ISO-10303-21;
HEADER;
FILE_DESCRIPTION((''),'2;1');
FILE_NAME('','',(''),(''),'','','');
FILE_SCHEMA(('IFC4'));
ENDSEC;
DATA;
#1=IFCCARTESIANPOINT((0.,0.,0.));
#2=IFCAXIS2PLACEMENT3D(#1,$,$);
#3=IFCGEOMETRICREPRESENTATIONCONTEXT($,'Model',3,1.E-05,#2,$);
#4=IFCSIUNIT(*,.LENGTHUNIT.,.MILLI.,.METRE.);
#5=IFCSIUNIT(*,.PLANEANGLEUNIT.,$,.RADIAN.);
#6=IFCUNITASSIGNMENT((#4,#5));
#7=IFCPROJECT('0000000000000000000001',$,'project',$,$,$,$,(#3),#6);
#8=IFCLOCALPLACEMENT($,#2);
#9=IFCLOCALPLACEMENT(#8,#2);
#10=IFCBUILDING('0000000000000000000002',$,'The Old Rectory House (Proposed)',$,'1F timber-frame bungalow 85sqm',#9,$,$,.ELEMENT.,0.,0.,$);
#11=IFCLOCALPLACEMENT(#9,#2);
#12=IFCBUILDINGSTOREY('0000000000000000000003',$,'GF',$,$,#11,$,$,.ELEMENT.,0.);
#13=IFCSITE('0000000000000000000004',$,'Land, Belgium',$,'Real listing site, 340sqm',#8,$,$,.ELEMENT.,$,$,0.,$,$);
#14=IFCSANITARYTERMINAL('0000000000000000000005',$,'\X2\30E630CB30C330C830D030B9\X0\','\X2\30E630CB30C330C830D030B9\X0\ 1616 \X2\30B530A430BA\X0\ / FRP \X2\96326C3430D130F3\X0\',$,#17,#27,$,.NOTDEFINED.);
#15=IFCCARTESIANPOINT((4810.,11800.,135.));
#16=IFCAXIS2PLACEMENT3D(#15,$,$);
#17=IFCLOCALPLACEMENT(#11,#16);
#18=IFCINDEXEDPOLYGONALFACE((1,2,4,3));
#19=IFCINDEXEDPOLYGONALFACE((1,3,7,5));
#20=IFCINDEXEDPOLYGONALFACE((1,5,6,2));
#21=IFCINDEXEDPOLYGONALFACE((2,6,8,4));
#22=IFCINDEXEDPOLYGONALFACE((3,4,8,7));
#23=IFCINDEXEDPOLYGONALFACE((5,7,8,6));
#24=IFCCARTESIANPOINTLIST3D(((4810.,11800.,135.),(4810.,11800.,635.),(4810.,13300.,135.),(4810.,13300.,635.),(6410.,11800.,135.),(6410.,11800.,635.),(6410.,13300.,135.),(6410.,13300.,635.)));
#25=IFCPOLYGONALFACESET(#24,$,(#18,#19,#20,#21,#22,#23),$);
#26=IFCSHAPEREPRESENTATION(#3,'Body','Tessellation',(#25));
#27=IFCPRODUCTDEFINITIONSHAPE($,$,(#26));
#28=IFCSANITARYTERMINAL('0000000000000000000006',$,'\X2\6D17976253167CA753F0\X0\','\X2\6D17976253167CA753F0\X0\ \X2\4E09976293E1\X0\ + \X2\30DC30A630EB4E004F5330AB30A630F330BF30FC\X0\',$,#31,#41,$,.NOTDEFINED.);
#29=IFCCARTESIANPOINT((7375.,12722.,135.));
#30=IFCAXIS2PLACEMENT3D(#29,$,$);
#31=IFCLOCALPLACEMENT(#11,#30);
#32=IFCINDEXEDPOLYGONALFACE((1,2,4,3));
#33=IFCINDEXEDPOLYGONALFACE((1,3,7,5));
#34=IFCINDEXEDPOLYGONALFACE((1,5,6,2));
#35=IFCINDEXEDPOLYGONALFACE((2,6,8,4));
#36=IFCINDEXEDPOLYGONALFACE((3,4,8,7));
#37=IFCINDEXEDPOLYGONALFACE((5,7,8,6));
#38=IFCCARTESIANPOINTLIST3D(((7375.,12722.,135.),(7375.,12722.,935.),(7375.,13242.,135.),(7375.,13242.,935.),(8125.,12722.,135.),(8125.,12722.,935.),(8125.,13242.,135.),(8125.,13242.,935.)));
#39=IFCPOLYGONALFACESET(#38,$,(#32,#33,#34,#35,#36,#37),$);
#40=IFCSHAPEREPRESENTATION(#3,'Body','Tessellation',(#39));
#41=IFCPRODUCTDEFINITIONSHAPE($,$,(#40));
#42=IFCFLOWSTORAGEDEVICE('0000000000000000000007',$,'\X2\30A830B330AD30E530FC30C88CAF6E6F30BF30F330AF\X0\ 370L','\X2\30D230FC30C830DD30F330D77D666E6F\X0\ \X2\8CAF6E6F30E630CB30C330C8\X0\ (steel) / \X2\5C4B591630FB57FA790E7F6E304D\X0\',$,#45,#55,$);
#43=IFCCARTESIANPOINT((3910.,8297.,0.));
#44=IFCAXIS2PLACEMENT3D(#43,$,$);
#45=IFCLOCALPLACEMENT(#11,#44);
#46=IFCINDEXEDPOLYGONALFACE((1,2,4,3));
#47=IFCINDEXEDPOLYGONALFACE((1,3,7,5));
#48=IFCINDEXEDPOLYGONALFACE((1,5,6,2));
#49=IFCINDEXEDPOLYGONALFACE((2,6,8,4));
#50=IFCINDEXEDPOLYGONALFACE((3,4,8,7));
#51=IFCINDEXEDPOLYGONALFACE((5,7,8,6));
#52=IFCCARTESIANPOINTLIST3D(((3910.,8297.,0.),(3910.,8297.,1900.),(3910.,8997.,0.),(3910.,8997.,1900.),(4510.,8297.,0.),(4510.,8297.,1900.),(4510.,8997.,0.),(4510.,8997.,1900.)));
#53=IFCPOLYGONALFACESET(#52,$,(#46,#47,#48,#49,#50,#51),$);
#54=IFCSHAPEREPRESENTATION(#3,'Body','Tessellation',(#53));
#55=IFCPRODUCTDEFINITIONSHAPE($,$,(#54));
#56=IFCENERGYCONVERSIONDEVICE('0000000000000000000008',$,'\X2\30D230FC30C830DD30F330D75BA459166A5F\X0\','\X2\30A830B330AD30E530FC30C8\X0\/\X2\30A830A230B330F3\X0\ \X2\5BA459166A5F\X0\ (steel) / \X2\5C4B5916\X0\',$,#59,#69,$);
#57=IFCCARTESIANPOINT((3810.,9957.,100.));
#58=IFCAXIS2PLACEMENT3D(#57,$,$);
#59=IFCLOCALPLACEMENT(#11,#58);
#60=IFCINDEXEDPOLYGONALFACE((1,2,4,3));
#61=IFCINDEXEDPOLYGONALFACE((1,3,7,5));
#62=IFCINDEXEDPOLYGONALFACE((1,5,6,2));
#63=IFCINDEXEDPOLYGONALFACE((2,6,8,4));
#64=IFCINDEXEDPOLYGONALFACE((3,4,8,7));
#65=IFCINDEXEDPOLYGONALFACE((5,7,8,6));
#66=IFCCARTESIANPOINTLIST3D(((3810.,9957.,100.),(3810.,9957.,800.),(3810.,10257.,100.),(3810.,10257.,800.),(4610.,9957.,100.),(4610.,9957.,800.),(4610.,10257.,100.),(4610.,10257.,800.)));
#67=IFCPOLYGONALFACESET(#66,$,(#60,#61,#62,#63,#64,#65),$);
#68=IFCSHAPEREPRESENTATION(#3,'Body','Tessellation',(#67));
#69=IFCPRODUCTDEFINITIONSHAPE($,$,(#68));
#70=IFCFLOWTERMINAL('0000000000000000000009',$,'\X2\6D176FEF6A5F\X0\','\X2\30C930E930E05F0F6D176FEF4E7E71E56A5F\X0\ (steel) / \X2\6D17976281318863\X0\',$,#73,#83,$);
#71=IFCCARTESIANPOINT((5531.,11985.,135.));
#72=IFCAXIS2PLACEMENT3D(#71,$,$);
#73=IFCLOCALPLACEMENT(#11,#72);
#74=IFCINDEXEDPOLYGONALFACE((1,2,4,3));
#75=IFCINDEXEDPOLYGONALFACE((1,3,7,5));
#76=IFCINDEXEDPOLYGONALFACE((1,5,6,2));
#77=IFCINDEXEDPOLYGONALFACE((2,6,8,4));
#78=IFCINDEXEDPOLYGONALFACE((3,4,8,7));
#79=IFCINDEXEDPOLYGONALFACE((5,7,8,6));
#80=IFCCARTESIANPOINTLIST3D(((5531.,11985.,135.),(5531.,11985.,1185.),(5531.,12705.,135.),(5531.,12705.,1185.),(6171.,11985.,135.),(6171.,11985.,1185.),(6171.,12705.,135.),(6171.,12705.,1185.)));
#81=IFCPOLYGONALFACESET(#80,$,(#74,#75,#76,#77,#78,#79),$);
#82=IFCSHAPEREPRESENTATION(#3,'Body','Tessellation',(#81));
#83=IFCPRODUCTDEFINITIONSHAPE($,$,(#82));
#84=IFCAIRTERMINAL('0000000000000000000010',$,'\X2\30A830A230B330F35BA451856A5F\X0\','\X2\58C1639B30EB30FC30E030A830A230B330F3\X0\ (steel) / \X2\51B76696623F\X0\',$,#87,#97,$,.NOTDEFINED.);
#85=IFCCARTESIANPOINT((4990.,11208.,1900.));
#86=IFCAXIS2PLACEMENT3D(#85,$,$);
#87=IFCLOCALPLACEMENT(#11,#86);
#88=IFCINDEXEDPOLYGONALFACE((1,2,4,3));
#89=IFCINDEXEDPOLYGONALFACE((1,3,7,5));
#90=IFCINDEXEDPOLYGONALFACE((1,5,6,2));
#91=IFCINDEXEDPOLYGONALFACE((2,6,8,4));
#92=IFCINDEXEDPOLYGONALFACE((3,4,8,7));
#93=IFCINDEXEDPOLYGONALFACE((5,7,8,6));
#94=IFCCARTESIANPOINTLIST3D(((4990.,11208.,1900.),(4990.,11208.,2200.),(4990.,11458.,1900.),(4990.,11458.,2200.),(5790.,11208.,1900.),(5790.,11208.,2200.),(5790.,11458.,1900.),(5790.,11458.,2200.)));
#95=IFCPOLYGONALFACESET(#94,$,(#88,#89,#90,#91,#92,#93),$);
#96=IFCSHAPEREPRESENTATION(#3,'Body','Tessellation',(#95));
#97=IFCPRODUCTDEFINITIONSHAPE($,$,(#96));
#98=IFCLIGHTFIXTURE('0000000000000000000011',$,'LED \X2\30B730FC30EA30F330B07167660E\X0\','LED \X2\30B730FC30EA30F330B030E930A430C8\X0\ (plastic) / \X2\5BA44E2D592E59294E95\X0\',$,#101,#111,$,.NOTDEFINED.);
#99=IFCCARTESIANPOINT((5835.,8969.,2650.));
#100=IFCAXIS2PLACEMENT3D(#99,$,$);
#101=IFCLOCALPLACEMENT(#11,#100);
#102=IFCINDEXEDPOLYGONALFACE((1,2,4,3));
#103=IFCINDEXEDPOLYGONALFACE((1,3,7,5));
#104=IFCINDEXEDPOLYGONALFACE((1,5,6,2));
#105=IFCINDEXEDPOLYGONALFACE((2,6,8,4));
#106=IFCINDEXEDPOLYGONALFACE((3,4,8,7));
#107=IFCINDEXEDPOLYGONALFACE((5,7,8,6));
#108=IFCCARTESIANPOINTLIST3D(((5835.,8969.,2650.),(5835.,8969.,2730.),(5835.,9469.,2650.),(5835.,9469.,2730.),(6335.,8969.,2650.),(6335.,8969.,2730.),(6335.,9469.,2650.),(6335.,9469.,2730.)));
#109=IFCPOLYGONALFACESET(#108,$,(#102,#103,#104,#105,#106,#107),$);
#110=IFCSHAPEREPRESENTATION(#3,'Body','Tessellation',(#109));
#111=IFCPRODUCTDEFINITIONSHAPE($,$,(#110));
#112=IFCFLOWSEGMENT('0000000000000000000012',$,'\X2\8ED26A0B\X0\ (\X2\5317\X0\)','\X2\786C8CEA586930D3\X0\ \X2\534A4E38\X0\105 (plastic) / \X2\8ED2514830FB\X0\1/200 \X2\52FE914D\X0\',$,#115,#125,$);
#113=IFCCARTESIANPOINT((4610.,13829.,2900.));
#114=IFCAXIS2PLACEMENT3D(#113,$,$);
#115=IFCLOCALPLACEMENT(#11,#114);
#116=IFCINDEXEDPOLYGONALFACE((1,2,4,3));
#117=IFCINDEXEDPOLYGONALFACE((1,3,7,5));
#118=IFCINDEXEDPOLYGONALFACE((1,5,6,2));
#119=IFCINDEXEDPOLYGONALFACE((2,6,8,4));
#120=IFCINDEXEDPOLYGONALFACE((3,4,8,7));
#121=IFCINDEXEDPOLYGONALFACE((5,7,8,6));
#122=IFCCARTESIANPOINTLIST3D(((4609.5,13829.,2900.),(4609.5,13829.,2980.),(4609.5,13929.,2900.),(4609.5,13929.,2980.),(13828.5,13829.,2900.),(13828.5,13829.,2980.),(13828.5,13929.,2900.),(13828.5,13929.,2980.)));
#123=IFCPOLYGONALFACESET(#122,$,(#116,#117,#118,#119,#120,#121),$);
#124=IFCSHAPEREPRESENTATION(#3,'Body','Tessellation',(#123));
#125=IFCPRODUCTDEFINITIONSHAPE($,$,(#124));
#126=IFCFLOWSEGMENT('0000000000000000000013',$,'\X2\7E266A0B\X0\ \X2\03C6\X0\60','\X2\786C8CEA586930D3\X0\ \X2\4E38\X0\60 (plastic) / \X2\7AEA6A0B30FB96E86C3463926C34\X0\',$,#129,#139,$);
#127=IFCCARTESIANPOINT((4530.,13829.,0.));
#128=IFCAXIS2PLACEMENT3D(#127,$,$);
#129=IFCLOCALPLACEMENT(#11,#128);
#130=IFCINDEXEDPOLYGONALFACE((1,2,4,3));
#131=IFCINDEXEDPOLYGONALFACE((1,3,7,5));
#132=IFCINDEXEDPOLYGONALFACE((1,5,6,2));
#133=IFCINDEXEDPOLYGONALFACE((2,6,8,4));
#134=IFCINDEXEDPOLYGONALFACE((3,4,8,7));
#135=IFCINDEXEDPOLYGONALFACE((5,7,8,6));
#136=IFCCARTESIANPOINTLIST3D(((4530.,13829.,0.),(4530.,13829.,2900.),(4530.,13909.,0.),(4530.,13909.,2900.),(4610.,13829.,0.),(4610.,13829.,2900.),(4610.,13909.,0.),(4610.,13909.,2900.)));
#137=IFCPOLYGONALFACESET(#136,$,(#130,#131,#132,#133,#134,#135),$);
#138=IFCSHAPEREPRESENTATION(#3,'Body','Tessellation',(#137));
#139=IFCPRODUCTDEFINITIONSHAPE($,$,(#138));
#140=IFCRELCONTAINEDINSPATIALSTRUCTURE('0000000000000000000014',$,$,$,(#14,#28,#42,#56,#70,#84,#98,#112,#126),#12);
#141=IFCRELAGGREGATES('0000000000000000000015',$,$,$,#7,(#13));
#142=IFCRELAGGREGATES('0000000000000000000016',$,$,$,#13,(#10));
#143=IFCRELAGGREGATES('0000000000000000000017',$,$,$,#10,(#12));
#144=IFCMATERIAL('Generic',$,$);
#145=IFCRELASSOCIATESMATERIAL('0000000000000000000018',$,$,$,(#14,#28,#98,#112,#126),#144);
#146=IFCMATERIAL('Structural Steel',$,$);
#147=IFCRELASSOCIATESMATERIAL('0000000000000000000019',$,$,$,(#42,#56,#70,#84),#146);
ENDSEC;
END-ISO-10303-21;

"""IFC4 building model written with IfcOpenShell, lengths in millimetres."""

from ifc_helpers import new_model, si_unit, frame, frame_2d, origin, place, context, project, spatial, rectangle, extrude, material, element, save


model = new_model("IFC4")

# Units and contexts
model_context = context("Model", 3, precision=1e-05, world=origin())
ifc_project = project(units=[si_unit("LENGTHUNIT", "METRE", prefix="MILLI"), si_unit("PLANEANGLEUNIT", "RADIAN")], contexts=[model_context])

# Site, building, storey
site_placement = place(None, origin())
site = spatial("IfcSite", under=ifc_project, at=site_placement, Name="Land, Belgium", ObjectType="Real listing site, 340sqm", CompositionType="ELEMENT", RefElevation=0.0)
building_placement = place(site_placement, origin())
building = spatial("IfcBuilding", under=site, at=building_placement, Name="The Old Rectory House (Proposed)", ObjectType="1F timber-frame bungalow 85sqm", CompositionType="ELEMENT", ElevationOfRefHeight=0.0, ElevationOfTerrain=0.0)
storey_placement = place(building_placement, origin())
storey = spatial("IfcBuildingStorey", under=building, at=storey_placement, Name="GF", CompositionType="ELEMENT", Elevation=0.0)

# Shared definitions
ifc_material_1 = material(Name="Structural Steel")

# Shared definitions
ifc_material_2 = material(Name="Generic")

# Sanitary terminals
sanitary_terminal_1_placement = place(storey_placement, frame((4810.0, 11800.0, 135.0)))
element("IfcSanitaryTerminal", 1, at=sanitary_terminal_1_placement, inside=storey, material=ifc_material_2, Name="ユニットバス", Description="ユニットバス 1616 サイズ / FRP 防水パン", PredefinedType="NOTDEFINED", context=model_context, shape_type="SweptSolid", body=[
    extrude(rectangle(XDim=1600.0, YDim=1500.0, at=frame_2d((800.0, 750.0))), frame((4810.0, 11800.0, 135.0)), (0.0, 0.0, 1.0), 500.0),
])
sanitary_terminal_2_placement = place(storey_placement, frame((7375.0, 12722.0, 135.0)))
element("IfcSanitaryTerminal", 2, at=sanitary_terminal_2_placement, inside=storey, material=ifc_material_2, Name="洗面化粧台", Description="洗面化粧台 三面鏡 + ボウル一体カウンター", PredefinedType="NOTDEFINED", context=model_context, shape_type="SweptSolid", body=[
    extrude(rectangle(XDim=750.0, YDim=520.0, at=frame_2d((375.0, 260.0))), frame((7375.0, 12722.0, 135.0)), (0.0, 0.0, 1.0), 800.0),
])

# Flow storage device
flow_storage_device_placement = place(storey_placement, frame((3910.0, 8297.0, 0.0)))
element("IfcFlowStorageDevice", 3, at=flow_storage_device_placement, inside=storey, material=ifc_material_1, Name="エコキュート貯湯タンク 370L", Description="ヒートポンプ給湯 貯湯ユニット (steel) / 屋外・基礎置き", context=model_context, shape_type="SweptSolid", body=[
    extrude(rectangle(XDim=600.0, YDim=700.0, at=frame_2d((300.0, 350.0))), frame((3910.0, 8297.0, 0.0)), (0.0, 0.0, 1.0), 1900.0),
])

# Energy conversion device
energy_conversion_device_placement = place(storey_placement, frame((3810.0, 9957.0, 100.0)))
element("IfcEnergyConversionDevice", 4, at=energy_conversion_device_placement, inside=storey, material=ifc_material_1, Name="ヒートポンプ室外機", Description="エコキュート/エアコン 室外機 (steel) / 屋外", context=model_context, shape_type="SweptSolid", body=[
    extrude(rectangle(XDim=800.0, YDim=300.0, at=frame_2d((400.0, 150.0))), frame((3810.0, 9957.0, 100.0)), (0.0, 0.0, 1.0), 700.0),
])

# Flow terminal
flow_terminal_placement = place(storey_placement, frame((5531.0, 11985.0, 135.0)))
element("IfcFlowTerminal", 5, at=flow_terminal_placement, inside=storey, material=ifc_material_1, Name="洗濯機", Description="ドラム式洗濯乾燥機 (steel) / 洗面脱衣", context=model_context, shape_type="SweptSolid", body=[
    extrude(rectangle(XDim=640.0, YDim=720.0, at=frame_2d((320.0, 360.0))), frame((5531.0, 11985.0, 135.0)), (0.0, 0.0, 1.0), 1050.0),
])

# Air terminal
air_terminal_placement = place(storey_placement, frame((4990.0, 11208.0, 1900.0)))
element("IfcAirTerminal", 6, at=air_terminal_placement, inside=storey, material=ifc_material_1, Name="エアコン室内機", Description="壁掛ルームエアコン (steel) / 冷暖房", PredefinedType="NOTDEFINED", context=model_context, shape_type="SweptSolid", body=[
    extrude(rectangle(XDim=800.0, YDim=250.0, at=frame_2d((400.0, 125.0))), frame((4990.0, 11208.0, 1900.0)), (0.0, 0.0, 1.0), 300.0),
])

# Light fixture
light_fixture_placement = place(storey_placement, frame((5835.0, 8969.0, 2650.0)))
element("IfcLightFixture", 7, at=light_fixture_placement, inside=storey, material=ifc_material_2, Name="LED シーリング照明", Description="LED シーリングライト (plastic) / 室中央天井", PredefinedType="NOTDEFINED", context=model_context, shape_type="SweptSolid", body=[
    extrude(rectangle(XDim=500.0, YDim=500.0, at=frame_2d((250.0, 250.0))), frame((5835.0, 8969.0, 2650.0)), (0.0, 0.0, 1.0), 80.0),
])

# Flow segments
flow_segment_1_placement = place(storey_placement, frame((4610.0, 13829.0, 2900.0)))
element("IfcFlowSegment", 8, at=flow_segment_1_placement, inside=storey, material=ifc_material_2, Name="軒樋 (北)", Description="硬質塩ビ 半丸105 (plastic) / 軒先・1/200 勾配", context=model_context, shape_type="SweptSolid", body=[
    extrude(rectangle(XDim=9219.0, YDim=100.0, at=frame_2d((4609.0, 50.0))), frame((4610.0, 13829.0, 2900.0)), (0.0, 0.0, 1.0), 80.0),
])
flow_segment_2_placement = place(storey_placement, frame((4530.0, 13829.0, 0.0)))
element("IfcFlowSegment", 9, at=flow_segment_2_placement, inside=storey, material=ifc_material_2, Name="縦樋 φ60", Description="硬質塩ビ 丸60 (plastic) / 竪樋・雨水排水", context=model_context, shape_type="SweptSolid", body=[
    extrude(rectangle(XDim=80.0, YDim=80.0, at=frame_2d((40.0, 40.0))), frame((4530.0, 13829.0, 0.0)), (0.0, 0.0, 1.0), 2900.0),
])

save(model, "model.ifc")
